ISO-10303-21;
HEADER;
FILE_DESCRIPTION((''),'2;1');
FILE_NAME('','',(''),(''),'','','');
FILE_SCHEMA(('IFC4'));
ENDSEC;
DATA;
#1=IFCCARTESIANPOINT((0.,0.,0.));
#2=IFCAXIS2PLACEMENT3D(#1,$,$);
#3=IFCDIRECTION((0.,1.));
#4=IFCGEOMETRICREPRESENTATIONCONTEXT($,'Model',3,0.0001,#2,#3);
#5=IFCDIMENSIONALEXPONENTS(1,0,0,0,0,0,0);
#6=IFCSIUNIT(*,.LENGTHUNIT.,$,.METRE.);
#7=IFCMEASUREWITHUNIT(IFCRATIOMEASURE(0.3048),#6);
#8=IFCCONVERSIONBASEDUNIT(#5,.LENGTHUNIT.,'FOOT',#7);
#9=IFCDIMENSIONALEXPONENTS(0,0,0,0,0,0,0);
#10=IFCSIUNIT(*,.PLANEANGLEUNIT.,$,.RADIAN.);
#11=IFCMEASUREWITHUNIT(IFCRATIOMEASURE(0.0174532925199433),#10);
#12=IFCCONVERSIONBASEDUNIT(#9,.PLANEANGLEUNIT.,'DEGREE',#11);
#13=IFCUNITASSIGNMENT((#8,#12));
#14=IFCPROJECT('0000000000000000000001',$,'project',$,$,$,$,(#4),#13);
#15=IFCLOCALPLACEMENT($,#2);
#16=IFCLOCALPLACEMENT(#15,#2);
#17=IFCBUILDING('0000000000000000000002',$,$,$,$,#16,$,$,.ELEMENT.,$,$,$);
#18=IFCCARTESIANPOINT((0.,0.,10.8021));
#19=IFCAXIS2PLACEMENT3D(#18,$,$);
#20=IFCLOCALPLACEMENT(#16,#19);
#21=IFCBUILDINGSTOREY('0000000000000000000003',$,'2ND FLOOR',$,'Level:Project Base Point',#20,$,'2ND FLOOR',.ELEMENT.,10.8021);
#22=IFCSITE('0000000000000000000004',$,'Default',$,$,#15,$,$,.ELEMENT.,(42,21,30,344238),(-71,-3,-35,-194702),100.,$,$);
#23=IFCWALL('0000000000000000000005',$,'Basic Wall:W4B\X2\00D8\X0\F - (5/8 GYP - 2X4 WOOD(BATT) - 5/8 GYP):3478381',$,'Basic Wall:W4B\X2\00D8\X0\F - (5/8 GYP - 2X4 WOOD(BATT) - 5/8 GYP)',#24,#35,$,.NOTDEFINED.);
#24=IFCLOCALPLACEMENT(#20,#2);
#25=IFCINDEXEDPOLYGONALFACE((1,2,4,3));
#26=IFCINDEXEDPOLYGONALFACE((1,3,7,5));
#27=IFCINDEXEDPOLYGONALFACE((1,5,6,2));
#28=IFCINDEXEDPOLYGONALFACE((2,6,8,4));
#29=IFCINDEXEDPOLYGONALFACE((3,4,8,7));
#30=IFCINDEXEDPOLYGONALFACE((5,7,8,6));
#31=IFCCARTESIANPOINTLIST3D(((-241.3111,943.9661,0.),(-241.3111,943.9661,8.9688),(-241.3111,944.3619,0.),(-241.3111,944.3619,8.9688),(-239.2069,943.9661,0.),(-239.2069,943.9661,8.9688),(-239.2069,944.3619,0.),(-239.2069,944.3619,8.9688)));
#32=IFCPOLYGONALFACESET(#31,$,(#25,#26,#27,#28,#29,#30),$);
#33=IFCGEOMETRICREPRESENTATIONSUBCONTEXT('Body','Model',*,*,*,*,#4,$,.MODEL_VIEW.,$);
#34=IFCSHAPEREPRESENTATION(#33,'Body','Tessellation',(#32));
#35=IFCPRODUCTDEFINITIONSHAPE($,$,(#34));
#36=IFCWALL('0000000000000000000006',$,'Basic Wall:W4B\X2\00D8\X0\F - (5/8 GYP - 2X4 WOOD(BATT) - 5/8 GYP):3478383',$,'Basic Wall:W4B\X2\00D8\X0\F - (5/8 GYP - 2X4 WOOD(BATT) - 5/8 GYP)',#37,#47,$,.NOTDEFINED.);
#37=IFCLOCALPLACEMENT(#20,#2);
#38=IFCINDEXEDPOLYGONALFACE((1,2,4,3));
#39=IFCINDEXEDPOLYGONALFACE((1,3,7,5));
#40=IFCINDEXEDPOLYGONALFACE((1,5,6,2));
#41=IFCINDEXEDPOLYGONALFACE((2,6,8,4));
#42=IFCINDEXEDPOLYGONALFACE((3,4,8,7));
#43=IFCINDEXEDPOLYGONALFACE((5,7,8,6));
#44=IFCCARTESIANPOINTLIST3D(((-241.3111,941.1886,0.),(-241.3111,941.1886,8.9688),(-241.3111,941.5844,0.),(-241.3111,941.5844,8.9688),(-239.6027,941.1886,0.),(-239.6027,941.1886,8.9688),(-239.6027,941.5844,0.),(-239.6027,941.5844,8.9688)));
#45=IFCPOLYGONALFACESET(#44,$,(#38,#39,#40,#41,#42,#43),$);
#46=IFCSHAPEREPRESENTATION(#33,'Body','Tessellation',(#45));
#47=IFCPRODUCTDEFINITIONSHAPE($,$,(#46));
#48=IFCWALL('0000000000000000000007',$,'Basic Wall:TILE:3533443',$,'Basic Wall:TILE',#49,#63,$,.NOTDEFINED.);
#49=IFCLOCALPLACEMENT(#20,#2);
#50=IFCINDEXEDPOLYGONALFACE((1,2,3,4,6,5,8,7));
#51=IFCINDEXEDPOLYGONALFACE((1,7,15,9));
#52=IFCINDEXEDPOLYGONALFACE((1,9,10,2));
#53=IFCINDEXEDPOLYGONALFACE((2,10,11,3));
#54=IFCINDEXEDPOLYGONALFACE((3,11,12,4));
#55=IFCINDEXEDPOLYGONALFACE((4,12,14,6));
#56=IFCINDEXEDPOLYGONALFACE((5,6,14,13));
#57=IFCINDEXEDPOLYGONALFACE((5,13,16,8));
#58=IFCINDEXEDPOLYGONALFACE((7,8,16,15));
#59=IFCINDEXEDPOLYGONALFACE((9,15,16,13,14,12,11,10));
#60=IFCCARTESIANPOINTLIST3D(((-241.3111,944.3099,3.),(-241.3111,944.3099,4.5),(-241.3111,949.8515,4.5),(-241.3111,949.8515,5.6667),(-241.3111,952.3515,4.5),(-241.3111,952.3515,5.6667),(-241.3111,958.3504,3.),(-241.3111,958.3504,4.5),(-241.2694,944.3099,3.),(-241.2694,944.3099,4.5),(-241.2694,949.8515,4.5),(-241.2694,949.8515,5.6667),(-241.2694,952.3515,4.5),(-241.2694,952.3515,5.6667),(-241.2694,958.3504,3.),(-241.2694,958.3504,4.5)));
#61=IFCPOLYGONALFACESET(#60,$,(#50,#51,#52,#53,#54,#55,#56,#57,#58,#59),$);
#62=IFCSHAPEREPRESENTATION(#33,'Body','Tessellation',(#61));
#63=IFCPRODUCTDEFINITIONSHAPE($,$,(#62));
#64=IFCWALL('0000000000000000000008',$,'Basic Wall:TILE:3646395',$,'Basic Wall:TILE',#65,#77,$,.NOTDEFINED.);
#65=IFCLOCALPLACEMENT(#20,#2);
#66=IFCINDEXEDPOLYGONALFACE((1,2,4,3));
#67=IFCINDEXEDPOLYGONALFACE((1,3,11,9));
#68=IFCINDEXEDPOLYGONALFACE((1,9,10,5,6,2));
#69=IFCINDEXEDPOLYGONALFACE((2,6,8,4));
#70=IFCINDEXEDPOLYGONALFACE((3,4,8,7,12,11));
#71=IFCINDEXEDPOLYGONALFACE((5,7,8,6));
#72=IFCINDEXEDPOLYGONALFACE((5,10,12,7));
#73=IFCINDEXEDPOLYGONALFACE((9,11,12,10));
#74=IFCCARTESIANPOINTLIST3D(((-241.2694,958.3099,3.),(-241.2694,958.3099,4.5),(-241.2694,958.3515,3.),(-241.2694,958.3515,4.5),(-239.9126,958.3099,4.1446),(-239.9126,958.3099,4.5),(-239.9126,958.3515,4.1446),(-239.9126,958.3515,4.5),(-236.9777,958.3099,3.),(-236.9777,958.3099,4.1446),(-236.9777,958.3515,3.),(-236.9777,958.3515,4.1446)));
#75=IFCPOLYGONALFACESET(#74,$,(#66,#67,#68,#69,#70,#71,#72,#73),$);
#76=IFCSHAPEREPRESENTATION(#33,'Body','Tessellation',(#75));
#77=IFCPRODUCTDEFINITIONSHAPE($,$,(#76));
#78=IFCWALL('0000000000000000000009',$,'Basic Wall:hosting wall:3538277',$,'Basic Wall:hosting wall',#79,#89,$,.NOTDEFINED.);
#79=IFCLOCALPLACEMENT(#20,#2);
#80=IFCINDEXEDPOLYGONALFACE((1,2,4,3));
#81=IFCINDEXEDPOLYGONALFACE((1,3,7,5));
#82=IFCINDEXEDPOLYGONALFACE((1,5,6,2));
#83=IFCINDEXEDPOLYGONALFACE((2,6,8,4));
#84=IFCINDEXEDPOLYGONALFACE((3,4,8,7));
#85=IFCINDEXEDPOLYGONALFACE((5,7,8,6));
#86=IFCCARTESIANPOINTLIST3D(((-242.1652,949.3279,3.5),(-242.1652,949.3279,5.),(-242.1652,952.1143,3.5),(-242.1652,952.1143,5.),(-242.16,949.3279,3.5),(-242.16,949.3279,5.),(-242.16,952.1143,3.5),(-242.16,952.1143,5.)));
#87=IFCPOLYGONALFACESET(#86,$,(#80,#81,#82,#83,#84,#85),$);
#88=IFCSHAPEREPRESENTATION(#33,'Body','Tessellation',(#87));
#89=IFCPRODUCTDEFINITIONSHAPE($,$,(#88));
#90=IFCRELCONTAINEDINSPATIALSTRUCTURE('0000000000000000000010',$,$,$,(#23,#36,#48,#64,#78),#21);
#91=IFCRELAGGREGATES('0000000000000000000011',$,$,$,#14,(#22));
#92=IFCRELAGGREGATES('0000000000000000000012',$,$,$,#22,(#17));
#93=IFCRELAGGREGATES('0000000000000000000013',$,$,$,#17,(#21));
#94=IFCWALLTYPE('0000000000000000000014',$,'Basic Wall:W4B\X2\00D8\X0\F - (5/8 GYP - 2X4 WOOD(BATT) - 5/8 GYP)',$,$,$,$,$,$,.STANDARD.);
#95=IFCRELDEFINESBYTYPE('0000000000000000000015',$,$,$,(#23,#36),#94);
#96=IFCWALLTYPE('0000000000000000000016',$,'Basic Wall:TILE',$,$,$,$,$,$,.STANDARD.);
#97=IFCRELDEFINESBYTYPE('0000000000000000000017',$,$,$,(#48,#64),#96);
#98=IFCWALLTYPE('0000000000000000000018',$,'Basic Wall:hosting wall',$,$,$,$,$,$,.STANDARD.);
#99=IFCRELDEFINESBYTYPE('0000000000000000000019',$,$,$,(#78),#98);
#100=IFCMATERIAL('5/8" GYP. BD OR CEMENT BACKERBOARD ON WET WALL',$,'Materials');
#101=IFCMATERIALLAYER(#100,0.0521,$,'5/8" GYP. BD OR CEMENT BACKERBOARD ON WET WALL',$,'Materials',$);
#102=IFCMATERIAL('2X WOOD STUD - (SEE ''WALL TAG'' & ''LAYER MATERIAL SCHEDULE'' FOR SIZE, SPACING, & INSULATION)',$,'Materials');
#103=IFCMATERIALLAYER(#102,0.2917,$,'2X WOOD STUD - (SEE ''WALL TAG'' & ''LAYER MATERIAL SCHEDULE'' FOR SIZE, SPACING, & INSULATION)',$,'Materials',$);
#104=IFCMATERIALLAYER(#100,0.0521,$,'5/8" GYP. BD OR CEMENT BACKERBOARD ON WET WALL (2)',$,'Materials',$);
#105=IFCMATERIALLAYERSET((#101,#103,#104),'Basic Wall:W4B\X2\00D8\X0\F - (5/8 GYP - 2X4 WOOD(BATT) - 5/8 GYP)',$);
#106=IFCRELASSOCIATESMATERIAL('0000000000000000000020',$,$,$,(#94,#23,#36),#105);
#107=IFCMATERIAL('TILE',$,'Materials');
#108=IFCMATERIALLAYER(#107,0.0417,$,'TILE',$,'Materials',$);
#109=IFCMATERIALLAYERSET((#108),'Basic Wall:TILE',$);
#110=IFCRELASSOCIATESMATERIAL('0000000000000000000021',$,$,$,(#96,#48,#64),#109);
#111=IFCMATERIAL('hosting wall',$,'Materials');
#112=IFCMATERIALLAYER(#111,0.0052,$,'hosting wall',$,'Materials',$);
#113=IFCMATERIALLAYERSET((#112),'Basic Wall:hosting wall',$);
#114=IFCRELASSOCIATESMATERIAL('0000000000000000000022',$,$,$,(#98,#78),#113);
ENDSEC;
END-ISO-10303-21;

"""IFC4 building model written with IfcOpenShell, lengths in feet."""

from ifc_helpers import new_model, entity, si_unit, converted_unit, direction, frame, frame_2d, origin, place, context, subcontext, project, spatial, rectangle, extrude, material, layer, layer_set, layer_usage, type_object, element, save


model = new_model("IFC4")

# Units and contexts
model_context = context("Model", 3, precision=0.0001, world=origin(), true_north=direction((0.0, 1.0)))
body_context = subcontext(model_context, "Body", "Model", "MODEL_VIEW")
ifc_project = project(units=[converted_unit("LENGTHUNIT", "FOOT", entity("IfcRatioMeasure", 0.3048), si_unit("LENGTHUNIT", "METRE"), dimensions=[1, 0, 0, 0, 0, 0, 0]), converted_unit("PLANEANGLEUNIT", "DEGREE", entity("IfcRatioMeasure", 0.0174532925199433), si_unit("PLANEANGLEUNIT", "RADIAN"), dimensions=[0, 0, 0, 0, 0, 0, 0])], contexts=[model_context])

# Site, building, storey
site_placement = place(None, origin())
site = spatial("IfcSite", under=ifc_project, at=site_placement, Name="Default", CompositionType="ELEMENT", RefLatitude=(42, 21, 30, 344238), RefLongitude=(-71, -3, -35, -194702), RefElevation=100.0)
building_placement = place(site_placement, origin())
building = spatial("IfcBuilding", under=site, at=building_placement, CompositionType="ELEMENT")
storey_placement = place(building_placement, frame((0.0, 0.0, 10.8021)))
storey = spatial("IfcBuildingStorey", under=building, at=storey_placement, Name="2ND FLOOR", ObjectType="Level:Project Base Point", LongName="2ND FLOOR", CompositionType="ELEMENT", Elevation=10.8021)

# Wall
ifc_material_1 = material(Name="5/8\" GYP. BD OR CEMENT BACKERBOARD ON WET WALL", Category="Materials")
ifc_layer_1 = layer(ifc_material_1, 0.0521, Name="5/8\" GYP. BD OR CEMENT BACKERBOARD ON WET WALL", Category="Materials")
ifc_material_2 = material(Name="2X WOOD STUD - (SEE 'WALL TAG' & 'LAYER MATERIAL SCHEDULE' FOR SIZE, SPACING, & INSULATION)", Category="Materials")
ifc_layer_2 = layer(ifc_material_2, 0.2917, Name="2X WOOD STUD - (SEE 'WALL TAG' & 'LAYER MATERIAL SCHEDULE' FOR SIZE, SPACING, & INSULATION)", Category="Materials")
ifc_layer_3 = layer(ifc_material_1, 0.0521, Name="5/8\" GYP. BD OR CEMENT BACKERBOARD ON WET WALL (2)", Category="Materials")
ifc_layer_set_1 = layer_set([ifc_layer_1, ifc_layer_2, ifc_layer_3], Name="Basic Wall:W4BØF - (5/8 GYP - 2X4 WOOD(BATT) - 5/8 GYP)")
ifc_layer_usage_1 = layer_usage(ifc_layer_set_1, "AXIS2", "NEGATIVE", 0.1979)
wall_type_1 = type_object("IfcWallType", Name="Basic Wall:W4BØF - (5/8 GYP - 2X4 WOOD(BATT) - 5/8 GYP)", PredefinedType="STANDARD", material=ifc_layer_set_1)
wall_1_placement = place(storey_placement, frame((-241.3111, 944.164, 0.0)))
element("IfcWall", 1, at=wall_1_placement, inside=storey, type_object=wall_type_1, material=ifc_layer_usage_1, Name="Basic Wall:W4BØF - (5/8 GYP - 2X4 WOOD(BATT) - 5/8 GYP):3478381", ObjectType="Basic Wall:W4BØF - (5/8 GYP - 2X4 WOOD(BATT) - 5/8 GYP)", PredefinedType="NOTDEFINED", context=body_context, shape_type="SweptSolid", body=[
    extrude(rectangle(XDim=2.1042, YDim=0.3958, at=frame_2d((1.0521, 0.0), x_axis=(-1.0, 0.0))), origin(), (0.0, 0.0, 1.0), 8.9688),
])

# Wall
ifc_layer_usage_2 = layer_usage(ifc_layer_set_1, "AXIS2", "NEGATIVE", 0.1979)
wall_2_placement = place(storey_placement, frame((-239.6027, 941.3865, 0.0), z_axis=(0.0, 0.0, 1.0), x_axis=(-1.0, 0.0, 0.0)))
element("IfcWall", 2, at=wall_2_placement, inside=storey, type_object=wall_type_1, material=ifc_layer_usage_2, Name="Basic Wall:W4BØF - (5/8 GYP - 2X4 WOOD(BATT) - 5/8 GYP):3478383", ObjectType="Basic Wall:W4BØF - (5/8 GYP - 2X4 WOOD(BATT) - 5/8 GYP)", PredefinedType="NOTDEFINED", context=body_context, shape_type="SweptSolid", body=[
    extrude(rectangle(XDim=1.7083, YDim=0.3958, at=frame_2d((0.8542, 0.0), x_axis=(-1.0, 0.0))), origin(), (0.0, 0.0, 1.0), 8.9688),
])

# Wall, openings
ifc_material_3 = material(Name="TILE", Category="Materials")
ifc_layer_4 = layer(ifc_material_3, 0.0417, Name="TILE", Category="Materials")
ifc_layer_set_2 = layer_set([ifc_layer_4], Name="Basic Wall:TILE")
ifc_layer_usage_3 = layer_usage(ifc_layer_set_2, "AXIS2", "POSITIVE", -0.0208)
wall_type_2 = type_object("IfcWallType", Name="Basic Wall:TILE", PredefinedType="STANDARD", material=ifc_layer_set_2)
wall_3_placement = place(storey_placement, frame((-241.2902, 958.3504, 3.0), z_axis=(0.0, 0.0, 1.0), x_axis=(0.0, -1.0, 0.0)))
wall_3 = element("IfcWall", 3, at=wall_3_placement, inside=storey, type_object=wall_type_2, material=ifc_layer_usage_3, Name="Basic Wall:TILE:3533443", ObjectType="Basic Wall:TILE", PredefinedType="NOTDEFINED", context=body_context, shape_type="SweptSolid", body=[
    extrude(rectangle(XDim=14.0406, YDim=0.0417, at=frame_2d((7.0203, 0.0), x_axis=(-1.0, 0.0))), origin(), (0.0, 0.0, 1.0), 2.6667),
])
opening_1_placement = place(wall_3_placement, origin())
element("IfcOpeningElement", 4, at=opening_1_placement, cuts=wall_3, PredefinedType="OPENING", context=body_context, shape_type="SweptSolid", body=[
    extrude(rectangle(XDim=1.1667, YDim=5.5417, at=frame_2d((0.0, 0.0), x_axis=(1.0, 0.0))), frame((11.2697, 0.0208, 2.0833), z_axis=(0.0, -1.0, 0.0), x_axis=(0.0, 0.0, 1.0)), (0.0, 0.0, 1.0), 0.0417),
])
opening_2_placement = place(wall_3_placement, origin())
element("IfcOpeningElement", 5, at=opening_2_placement, cuts=wall_3, PredefinedType="OPENING", context=body_context, shape_type="SweptSolid", body=[
    extrude(rectangle(XDim=1.1667, YDim=5.9989, at=frame_2d((0.0, 0.0), x_axis=(0.0, 1.0))), frame((2.9994, 0.0208, 2.0833), z_axis=(0.0, -1.0, 0.0), x_axis=(-1.0, 0.0, 0.0)), (0.0, 0.0, 1.0), 0.0417),
])

# Wall, opening
ifc_layer_usage_4 = layer_usage(ifc_layer_set_2, "AXIS2", "NEGATIVE", 0.0208)
wall_4_placement = place(storey_placement, frame((-241.2694, 958.3307, 3.0)))
wall_4 = element("IfcWall", 6, at=wall_4_placement, inside=storey, type_object=wall_type_2, material=ifc_layer_usage_4, Name="Basic Wall:TILE:3646395", ObjectType="Basic Wall:TILE", PredefinedType="NOTDEFINED", context=body_context, shape_type="SweptSolid", body=[
    extrude(rectangle(XDim=4.2917, YDim=0.0417, at=frame_2d((2.1458, 0.0), x_axis=(-1.0, 0.0))), origin(), (0.0, 0.0, 1.0), 1.5),
])
opening_3_placement = place(wall_4_placement, origin())
element("IfcOpeningElement", 7, at=opening_3_placement, cuts=wall_4, PredefinedType="OPENING", context=body_context, shape_type="SweptSolid", body=[
    extrude(rectangle(XDim=0.3554, YDim=2.9349, at=frame_2d((0.0, 0.0), x_axis=(1.0, 0.0))), frame((2.8242, 0.0208, 1.3223), z_axis=(0.0, -1.0, 0.0), x_axis=(0.0, 0.0, 1.0)), (0.0, 0.0, 1.0), 0.0417),
])

# Wall
ifc_material_4 = material(Name="hosting wall", Category="Materials")
ifc_layer_5 = layer(ifc_material_4, 0.0052, Name="hosting wall", Category="Materials")
ifc_layer_set_3 = layer_set([ifc_layer_5], Name="Basic Wall:hosting wall")
ifc_layer_usage_5 = layer_usage(ifc_layer_set_3, "AXIS2", "POSITIVE", -0.0026)
wall_type_3 = type_object("IfcWallType", Name="Basic Wall:hosting wall", PredefinedType="STANDARD", material=ifc_layer_set_3)
wall_5_placement = place(storey_placement, frame((-242.1626, 949.3279, 3.5), z_axis=(0.0, 0.0, 1.0), x_axis=(0.0, 1.0, 0.0)))
element("IfcWall", 8, at=wall_5_placement, inside=storey, type_object=wall_type_3, material=ifc_layer_usage_5, Name="Basic Wall:hosting wall:3538277", ObjectType="Basic Wall:hosting wall", PredefinedType="NOTDEFINED", context=body_context, shape_type="SweptSolid", body=[
    extrude(rectangle(XDim=2.7865, YDim=0.0052, at=frame_2d((1.3932, 0.0), x_axis=(-1.0, 0.0))), origin(), (0.0, 0.0, 1.0), 1.5),
])

save(model, "model.ifc")
